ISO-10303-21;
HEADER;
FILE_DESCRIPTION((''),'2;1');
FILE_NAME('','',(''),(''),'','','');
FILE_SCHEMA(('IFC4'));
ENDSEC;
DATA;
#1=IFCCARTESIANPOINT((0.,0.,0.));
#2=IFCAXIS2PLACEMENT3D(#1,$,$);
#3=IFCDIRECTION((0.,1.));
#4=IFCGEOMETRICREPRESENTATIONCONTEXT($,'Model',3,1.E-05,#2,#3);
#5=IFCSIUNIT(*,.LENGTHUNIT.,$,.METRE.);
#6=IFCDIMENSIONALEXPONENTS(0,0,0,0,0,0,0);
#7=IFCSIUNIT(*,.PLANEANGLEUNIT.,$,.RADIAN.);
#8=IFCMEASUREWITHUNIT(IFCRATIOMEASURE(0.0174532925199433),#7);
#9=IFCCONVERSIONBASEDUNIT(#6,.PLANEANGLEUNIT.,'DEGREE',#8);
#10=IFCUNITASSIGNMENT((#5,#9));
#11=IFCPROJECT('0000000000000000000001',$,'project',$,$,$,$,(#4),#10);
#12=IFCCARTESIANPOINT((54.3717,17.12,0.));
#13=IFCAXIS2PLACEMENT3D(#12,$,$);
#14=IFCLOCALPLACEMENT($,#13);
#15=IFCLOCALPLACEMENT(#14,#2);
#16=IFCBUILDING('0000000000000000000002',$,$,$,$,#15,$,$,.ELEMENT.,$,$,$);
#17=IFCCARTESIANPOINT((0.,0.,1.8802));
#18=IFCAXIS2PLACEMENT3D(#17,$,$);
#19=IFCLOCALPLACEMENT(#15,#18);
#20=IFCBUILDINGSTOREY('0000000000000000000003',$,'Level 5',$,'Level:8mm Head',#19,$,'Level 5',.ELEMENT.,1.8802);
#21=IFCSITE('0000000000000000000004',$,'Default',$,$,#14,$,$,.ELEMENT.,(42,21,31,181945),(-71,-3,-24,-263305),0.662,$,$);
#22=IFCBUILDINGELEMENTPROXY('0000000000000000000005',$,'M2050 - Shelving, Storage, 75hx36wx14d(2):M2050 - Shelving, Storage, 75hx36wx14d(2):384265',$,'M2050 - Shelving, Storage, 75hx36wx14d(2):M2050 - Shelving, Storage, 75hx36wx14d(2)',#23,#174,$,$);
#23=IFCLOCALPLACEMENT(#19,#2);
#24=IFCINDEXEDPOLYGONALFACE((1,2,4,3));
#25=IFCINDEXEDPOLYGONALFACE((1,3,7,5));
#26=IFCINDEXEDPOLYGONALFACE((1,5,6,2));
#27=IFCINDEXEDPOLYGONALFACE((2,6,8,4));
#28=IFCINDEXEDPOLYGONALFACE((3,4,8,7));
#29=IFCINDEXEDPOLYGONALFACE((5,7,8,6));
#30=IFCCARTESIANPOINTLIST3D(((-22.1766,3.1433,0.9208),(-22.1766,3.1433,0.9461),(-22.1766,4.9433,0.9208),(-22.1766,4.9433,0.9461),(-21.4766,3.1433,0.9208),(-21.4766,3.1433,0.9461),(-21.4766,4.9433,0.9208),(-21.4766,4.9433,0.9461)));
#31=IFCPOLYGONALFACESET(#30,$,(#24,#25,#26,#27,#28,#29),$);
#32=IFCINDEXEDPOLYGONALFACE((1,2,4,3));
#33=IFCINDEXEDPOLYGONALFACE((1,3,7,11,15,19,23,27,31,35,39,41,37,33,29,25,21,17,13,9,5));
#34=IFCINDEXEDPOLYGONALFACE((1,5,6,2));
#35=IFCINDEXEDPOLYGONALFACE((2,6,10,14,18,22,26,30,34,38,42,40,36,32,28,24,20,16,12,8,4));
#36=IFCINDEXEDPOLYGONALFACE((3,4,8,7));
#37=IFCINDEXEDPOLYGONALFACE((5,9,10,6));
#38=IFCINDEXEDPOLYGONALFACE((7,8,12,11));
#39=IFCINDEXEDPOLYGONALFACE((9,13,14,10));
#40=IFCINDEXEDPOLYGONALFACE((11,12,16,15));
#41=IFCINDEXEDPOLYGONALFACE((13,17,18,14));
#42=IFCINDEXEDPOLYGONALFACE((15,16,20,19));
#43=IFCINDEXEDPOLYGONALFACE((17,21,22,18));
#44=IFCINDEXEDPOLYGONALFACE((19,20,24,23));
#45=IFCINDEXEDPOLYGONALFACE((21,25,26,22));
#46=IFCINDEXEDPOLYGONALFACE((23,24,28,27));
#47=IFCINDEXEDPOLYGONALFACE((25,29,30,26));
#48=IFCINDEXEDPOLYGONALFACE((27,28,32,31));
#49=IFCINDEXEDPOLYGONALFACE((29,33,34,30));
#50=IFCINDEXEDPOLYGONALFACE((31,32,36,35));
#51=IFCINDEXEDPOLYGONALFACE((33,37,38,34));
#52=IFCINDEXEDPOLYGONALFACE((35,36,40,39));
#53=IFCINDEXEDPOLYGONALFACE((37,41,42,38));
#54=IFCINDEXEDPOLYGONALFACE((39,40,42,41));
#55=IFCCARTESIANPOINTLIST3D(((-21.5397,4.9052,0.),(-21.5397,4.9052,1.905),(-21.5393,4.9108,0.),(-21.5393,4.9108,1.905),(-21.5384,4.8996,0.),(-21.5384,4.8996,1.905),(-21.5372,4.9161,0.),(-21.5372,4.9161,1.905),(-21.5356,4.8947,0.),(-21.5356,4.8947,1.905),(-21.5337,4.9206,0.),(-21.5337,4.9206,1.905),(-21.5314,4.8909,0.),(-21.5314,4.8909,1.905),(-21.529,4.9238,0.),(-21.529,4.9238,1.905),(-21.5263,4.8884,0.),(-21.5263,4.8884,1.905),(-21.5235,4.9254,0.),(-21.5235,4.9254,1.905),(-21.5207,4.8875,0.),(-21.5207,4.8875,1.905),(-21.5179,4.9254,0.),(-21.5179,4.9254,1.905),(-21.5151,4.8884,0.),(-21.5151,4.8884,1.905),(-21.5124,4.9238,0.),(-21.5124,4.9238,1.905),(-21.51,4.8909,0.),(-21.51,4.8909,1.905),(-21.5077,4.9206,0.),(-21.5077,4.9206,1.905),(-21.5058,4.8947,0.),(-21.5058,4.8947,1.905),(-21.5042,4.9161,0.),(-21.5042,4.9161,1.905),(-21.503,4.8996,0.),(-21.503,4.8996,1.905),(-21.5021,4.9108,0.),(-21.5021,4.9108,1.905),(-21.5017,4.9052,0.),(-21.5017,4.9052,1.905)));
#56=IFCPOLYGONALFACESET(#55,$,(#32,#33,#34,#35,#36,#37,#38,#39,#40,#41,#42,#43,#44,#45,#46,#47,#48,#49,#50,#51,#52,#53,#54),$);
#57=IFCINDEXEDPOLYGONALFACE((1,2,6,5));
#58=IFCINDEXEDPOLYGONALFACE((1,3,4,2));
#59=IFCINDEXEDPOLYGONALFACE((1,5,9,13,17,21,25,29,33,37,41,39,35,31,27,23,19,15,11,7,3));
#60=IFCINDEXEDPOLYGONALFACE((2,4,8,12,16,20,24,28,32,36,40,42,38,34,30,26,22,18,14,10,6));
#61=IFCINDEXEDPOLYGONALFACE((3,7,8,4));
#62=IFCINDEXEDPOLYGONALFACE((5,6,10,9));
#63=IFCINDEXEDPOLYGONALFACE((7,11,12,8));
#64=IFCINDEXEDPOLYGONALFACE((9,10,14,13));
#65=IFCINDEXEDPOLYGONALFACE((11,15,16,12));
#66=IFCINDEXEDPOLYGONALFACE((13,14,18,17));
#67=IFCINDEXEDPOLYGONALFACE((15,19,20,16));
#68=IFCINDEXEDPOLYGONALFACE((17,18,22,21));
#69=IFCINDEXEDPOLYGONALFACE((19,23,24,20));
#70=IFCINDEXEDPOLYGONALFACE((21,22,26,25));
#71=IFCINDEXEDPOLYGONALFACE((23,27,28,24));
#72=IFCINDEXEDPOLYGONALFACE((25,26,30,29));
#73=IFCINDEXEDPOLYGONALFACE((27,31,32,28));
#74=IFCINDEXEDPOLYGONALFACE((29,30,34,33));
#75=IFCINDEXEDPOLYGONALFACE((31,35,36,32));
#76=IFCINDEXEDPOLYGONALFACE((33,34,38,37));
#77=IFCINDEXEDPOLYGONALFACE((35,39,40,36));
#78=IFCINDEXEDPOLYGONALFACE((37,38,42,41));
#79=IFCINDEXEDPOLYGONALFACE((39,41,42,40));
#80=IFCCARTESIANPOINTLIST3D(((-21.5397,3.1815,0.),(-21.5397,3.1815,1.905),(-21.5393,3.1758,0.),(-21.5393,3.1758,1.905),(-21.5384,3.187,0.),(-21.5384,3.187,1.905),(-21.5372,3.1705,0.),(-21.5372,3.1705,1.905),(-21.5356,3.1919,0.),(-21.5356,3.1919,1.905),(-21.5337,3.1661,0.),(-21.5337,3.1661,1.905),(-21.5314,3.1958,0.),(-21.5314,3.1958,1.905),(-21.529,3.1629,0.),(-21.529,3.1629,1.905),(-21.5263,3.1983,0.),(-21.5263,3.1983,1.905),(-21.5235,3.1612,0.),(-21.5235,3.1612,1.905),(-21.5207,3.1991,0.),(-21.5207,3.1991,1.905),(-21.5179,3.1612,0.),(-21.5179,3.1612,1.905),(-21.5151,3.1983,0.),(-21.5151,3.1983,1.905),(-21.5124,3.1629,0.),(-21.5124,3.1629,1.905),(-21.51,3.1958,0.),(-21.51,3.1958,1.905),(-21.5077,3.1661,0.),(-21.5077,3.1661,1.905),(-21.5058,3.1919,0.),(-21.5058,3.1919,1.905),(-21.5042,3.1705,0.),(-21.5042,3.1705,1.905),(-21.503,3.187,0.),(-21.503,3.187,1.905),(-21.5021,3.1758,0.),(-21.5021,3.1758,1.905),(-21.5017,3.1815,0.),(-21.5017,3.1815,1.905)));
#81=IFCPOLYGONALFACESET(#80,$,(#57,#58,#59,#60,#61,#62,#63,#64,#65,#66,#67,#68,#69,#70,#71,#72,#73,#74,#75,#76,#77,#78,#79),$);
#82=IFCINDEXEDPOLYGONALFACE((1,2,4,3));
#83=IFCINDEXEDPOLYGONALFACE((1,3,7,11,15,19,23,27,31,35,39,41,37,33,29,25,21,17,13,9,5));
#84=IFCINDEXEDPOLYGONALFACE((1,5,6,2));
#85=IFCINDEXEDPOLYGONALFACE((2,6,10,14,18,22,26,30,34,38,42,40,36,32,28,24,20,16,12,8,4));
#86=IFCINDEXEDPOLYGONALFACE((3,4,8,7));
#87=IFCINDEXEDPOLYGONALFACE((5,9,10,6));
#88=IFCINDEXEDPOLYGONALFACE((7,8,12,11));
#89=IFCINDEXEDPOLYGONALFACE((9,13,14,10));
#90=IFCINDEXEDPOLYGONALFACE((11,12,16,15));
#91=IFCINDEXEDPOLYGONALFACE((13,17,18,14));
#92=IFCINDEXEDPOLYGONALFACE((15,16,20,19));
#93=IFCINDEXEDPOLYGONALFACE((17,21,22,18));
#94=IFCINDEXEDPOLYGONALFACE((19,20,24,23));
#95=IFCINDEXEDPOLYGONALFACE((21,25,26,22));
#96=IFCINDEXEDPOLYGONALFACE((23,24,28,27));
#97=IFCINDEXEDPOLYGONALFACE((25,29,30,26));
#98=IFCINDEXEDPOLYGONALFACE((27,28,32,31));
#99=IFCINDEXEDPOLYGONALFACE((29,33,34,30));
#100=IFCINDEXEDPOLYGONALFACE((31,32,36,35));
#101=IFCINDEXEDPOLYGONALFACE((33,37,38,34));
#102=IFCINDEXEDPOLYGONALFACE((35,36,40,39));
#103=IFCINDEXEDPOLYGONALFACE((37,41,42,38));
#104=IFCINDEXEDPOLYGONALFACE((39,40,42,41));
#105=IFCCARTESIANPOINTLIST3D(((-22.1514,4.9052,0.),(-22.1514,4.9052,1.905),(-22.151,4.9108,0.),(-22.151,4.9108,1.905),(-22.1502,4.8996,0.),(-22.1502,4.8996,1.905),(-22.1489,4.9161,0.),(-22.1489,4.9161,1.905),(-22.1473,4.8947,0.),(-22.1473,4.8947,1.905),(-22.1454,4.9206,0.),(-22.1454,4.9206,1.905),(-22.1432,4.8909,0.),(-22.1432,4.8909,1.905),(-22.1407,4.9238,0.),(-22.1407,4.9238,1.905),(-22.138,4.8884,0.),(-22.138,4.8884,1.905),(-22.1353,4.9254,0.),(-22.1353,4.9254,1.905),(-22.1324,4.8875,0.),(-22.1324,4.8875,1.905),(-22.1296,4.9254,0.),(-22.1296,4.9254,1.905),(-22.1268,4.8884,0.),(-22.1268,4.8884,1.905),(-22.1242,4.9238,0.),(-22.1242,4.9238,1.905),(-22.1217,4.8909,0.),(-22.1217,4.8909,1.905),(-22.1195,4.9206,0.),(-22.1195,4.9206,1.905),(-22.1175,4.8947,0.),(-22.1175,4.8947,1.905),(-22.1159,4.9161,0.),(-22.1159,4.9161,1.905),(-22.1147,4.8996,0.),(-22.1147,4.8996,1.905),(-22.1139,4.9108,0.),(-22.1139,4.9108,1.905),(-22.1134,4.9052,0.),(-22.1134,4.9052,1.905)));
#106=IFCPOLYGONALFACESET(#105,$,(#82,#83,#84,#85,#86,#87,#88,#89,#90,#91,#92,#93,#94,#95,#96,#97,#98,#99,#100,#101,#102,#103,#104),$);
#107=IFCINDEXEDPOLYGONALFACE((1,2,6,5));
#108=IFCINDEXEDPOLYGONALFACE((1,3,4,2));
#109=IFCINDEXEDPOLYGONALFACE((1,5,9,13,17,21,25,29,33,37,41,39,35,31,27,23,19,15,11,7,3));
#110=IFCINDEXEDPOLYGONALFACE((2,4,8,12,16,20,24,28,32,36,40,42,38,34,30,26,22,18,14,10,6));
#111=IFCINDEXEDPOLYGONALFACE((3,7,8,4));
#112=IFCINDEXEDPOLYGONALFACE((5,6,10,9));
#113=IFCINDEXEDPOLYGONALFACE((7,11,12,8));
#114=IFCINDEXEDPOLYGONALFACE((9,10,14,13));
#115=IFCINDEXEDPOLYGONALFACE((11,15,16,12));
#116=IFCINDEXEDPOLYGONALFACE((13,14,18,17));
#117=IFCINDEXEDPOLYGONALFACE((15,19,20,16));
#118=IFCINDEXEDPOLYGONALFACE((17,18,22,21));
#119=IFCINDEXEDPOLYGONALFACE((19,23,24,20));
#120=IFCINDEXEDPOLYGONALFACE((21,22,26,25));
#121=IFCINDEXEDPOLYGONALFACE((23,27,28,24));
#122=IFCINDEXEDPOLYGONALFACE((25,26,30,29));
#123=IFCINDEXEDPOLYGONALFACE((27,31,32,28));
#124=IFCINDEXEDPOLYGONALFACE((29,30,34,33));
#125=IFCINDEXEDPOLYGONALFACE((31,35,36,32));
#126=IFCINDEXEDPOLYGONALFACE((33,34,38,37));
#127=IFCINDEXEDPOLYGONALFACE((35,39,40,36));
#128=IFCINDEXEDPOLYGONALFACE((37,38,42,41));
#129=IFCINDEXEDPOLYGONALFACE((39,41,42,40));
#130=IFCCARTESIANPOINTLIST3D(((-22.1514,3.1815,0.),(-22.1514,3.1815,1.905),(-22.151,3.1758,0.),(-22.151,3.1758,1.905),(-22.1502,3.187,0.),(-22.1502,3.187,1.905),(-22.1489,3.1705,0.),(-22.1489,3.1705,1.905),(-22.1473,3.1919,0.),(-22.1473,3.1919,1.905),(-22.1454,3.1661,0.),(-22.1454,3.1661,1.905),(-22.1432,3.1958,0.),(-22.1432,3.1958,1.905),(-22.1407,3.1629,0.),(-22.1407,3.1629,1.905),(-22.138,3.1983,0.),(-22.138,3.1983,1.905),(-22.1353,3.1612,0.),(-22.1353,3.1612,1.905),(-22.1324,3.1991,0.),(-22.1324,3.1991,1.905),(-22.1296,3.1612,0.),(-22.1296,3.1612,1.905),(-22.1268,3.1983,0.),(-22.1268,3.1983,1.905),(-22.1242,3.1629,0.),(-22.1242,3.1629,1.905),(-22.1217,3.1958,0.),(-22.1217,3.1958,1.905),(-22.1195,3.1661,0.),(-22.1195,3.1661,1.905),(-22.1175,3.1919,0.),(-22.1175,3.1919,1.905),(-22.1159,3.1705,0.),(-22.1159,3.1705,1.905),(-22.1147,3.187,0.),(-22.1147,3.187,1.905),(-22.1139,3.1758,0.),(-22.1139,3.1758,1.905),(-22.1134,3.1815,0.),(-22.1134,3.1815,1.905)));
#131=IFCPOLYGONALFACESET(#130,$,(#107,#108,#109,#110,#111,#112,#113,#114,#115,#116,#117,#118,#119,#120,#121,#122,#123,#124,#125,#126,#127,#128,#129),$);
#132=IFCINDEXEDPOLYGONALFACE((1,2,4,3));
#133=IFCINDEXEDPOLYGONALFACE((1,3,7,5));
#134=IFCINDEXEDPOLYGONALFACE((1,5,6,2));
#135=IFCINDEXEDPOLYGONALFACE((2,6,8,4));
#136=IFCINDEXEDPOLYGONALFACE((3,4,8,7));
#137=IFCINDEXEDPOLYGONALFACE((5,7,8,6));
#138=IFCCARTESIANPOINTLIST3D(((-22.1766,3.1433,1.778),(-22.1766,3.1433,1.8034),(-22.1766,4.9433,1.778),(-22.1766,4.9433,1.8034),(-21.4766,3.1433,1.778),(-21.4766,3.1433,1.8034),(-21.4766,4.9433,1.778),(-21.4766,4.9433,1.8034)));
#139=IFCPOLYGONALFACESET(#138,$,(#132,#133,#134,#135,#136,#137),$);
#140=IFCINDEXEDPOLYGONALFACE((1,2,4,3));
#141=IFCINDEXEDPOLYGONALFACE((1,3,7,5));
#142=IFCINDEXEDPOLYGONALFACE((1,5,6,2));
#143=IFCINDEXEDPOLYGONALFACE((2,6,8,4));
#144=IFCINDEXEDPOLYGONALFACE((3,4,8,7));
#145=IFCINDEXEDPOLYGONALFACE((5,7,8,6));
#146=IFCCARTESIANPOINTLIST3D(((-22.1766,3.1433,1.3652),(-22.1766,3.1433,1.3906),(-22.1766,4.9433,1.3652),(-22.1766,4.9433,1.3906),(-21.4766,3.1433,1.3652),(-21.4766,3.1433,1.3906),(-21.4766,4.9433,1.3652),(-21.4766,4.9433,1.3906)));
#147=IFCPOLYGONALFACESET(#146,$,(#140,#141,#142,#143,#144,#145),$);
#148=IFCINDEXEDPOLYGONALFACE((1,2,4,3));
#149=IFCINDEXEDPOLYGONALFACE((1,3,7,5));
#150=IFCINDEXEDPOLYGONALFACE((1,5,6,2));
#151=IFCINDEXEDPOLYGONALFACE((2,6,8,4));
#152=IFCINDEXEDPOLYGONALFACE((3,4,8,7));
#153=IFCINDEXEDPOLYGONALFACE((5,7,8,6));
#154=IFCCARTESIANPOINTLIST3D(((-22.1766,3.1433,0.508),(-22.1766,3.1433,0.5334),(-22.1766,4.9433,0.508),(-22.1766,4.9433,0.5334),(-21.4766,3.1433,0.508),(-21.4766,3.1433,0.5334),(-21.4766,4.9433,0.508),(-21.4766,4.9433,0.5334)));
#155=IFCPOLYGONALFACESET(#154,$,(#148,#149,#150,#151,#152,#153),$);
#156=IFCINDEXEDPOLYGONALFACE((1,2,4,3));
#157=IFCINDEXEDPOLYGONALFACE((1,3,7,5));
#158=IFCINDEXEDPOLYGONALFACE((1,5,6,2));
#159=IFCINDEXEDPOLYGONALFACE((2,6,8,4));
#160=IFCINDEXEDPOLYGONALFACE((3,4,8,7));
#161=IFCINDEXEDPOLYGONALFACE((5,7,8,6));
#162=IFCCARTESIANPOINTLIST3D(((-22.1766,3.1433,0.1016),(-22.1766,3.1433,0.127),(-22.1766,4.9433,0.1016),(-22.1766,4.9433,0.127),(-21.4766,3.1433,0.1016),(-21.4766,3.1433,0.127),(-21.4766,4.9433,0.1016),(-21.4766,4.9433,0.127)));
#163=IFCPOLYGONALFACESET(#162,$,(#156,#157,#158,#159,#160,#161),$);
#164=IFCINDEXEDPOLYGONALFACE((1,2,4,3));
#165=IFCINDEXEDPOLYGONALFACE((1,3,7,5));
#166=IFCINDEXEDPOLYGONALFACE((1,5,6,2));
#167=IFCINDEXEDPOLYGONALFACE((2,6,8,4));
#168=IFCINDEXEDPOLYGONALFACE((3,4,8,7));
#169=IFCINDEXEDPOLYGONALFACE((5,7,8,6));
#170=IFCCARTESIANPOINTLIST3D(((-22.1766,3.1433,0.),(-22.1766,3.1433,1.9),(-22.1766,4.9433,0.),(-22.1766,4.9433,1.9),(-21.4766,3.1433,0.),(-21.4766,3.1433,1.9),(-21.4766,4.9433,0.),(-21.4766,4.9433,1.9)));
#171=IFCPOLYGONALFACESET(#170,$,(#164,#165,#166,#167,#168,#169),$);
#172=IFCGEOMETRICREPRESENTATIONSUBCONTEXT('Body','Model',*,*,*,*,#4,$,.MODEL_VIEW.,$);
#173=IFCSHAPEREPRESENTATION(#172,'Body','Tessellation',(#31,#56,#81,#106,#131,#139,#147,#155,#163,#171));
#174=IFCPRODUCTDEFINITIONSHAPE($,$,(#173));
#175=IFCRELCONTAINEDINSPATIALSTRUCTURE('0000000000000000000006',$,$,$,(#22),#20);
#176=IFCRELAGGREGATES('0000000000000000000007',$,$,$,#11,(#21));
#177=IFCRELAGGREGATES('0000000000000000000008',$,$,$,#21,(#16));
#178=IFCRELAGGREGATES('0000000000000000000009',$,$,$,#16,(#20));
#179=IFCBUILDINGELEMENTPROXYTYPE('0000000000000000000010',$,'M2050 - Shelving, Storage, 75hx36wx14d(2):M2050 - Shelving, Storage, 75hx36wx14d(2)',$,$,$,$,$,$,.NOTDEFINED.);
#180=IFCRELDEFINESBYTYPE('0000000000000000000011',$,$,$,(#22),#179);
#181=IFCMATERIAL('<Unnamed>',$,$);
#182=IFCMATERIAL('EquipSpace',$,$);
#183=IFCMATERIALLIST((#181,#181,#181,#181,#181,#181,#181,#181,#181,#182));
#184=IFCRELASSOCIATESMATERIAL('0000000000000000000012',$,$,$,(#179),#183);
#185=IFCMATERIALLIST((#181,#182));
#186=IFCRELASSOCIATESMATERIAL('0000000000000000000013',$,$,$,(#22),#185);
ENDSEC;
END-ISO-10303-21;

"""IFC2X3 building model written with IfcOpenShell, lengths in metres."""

from ifc_helpers import new_model, entity, si_unit, converted_unit, direction, frame, frame_2d, origin, origin_2d_with_axis, place, context, subcontext, project, spatial, rectangle, circle, extrude, source, transform, mapped, material, material_list, type_object, type_shapes, element, save


model = new_model("IFC2X3")

# Units and contexts
model_context = context("Model", 3, precision=1e-05, world=origin(), true_north=direction((0.0, 1.0)))
body_context = subcontext(model_context, "Body", "Model", "MODEL_VIEW")
ifc_project = project(units=[si_unit("LENGTHUNIT", "METRE"), converted_unit("PLANEANGLEUNIT", "DEGREE", entity("IfcRatioMeasure", 0.0174532925199433), si_unit("PLANEANGLEUNIT", "RADIAN"), dimensions=[0, 0, 0, 0, 0, 0, 0])], contexts=[model_context])

# Site, building, storey
site_placement = place(None, frame((54.3717, 17.12, 0.0)))
site = spatial("IfcSite", under=ifc_project, at=site_placement, Name="Default", CompositionType="ELEMENT", RefLatitude=(42, 21, 31, 181945), RefLongitude=(-71, -3, -24, -263305), RefElevation=0.662)
building_placement = place(site_placement, origin())
building = spatial("IfcBuilding", under=site, at=building_placement, CompositionType="ELEMENT")
storey_placement = place(building_placement, frame((0.0, 0.0, 1.8802)))
storey = spatial("IfcBuildingStorey", under=building, at=storey_placement, Name="Level 5", ObjectType="Level:8mm Head", LongName="Level 5", CompositionType="ELEMENT", Elevation=1.8802)

# Building element proxy
ifc_material_1 = material(Name="<Unnamed>")
ifc_material_2 = material(Name="EquipSpace")
ifc_material_list_1 = material_list([ifc_material_1, ifc_material_1, ifc_material_1, ifc_material_1, ifc_material_1, ifc_material_1, ifc_material_1, ifc_material_1, ifc_material_1, ifc_material_2])
building_element_proxy_type = type_object("IfcBuildingElementProxyType", Name="M2050 - Shelving, Storage, 75hx36wx14d(2):M2050 - Shelving, Storage, 75hx36wx14d(2)", PredefinedType="NOTDEFINED", material=ifc_material_list_1)
shared_shape = source(origin(), body_context, "Body", "SweptSolid", [
    extrude(rectangle(XDim=1.8, YDim=0.7, at=origin_2d_with_axis()), frame((0.0, 0.0, 0.9207), z_axis=(0.0, 0.0, 1.0), x_axis=(-1.0, 0.0, 0.0)), (0.0, 0.0, 1.0), 0.0254),
    extrude(circle(Radius=0.0191, at=origin_2d_with_axis()), frame((0.8633, -0.3059, 0.0), z_axis=(0.0, 0.0, 1.0), x_axis=(-1.0, 0.0, 0.0)), (0.0, 0.0, 1.0), 1.905),
    extrude(circle(Radius=0.0191, at=origin_2d_with_axis()), frame((-0.8633, -0.3059, 0.0)), (0.0, 0.0, 1.0), 1.905),
    extrude(circle(Radius=0.0191, at=origin_2d_with_axis()), frame((0.8633, 0.3059, 0.0), z_axis=(0.0, 0.0, 1.0), x_axis=(-1.0, 0.0, 0.0)), (0.0, 0.0, 1.0), 1.905),
    extrude(circle(Radius=0.0191, at=origin_2d_with_axis()), frame((-0.8633, 0.3059, 0.0)), (0.0, 0.0, 1.0), 1.905),
    extrude(rectangle(XDim=1.8, YDim=0.7, at=origin_2d_with_axis()), frame((0.0, 0.0, 1.778), z_axis=(0.0, 0.0, 1.0), x_axis=(-1.0, 0.0, 0.0)), (0.0, 0.0, 1.0), 0.0254),
    extrude(rectangle(XDim=1.8, YDim=0.7, at=origin_2d_with_axis()), frame((0.0, 0.0, 1.3653), z_axis=(0.0, 0.0, 1.0), x_axis=(-1.0, 0.0, 0.0)), (0.0, 0.0, 1.0), 0.0254),
    extrude(rectangle(XDim=1.8, YDim=0.7, at=origin_2d_with_axis()), frame((0.0, 0.0, 0.508), z_axis=(0.0, 0.0, 1.0), x_axis=(-1.0, 0.0, 0.0)), (0.0, 0.0, 1.0), 0.0254),
    extrude(rectangle(XDim=1.8, YDim=0.7, at=origin_2d_with_axis()), frame((0.0, 0.0, 0.1016), z_axis=(0.0, 0.0, 1.0), x_axis=(-1.0, 0.0, 0.0)), (0.0, 0.0, 1.0), 0.0254),
    extrude(rectangle(XDim=0.7, YDim=1.8, at=frame_2d((0.0, 0.18), x_axis=(1.0, 0.0))), frame((-0.18, 0.0, 0.0), z_axis=(0.0, 0.0, 1.0), x_axis=(0.0, -1.0, 0.0)), (0.0, 0.0, 1.0), 1.9),
])
type_shapes(building_element_proxy_type, [shared_shape])
ifc_material_list_2 = material_list([ifc_material_1, ifc_material_2])
proxy_1_placement = place(storey_placement, frame((-21.8266, 4.0433, 0.0), z_axis=(0.0, 0.0, 1.0), x_axis=(0.0, 1.0, 0.0)))
element("IfcBuildingElementProxy", 1, at=proxy_1_placement, inside=storey, type_object=building_element_proxy_type, material=ifc_material_list_2, Name="M2050 - Shelving, Storage, 75hx36wx14d(2):M2050 - Shelving, Storage, 75hx36wx14d(2):384265", ObjectType="M2050 - Shelving, Storage, 75hx36wx14d(2):M2050 - Shelving, Storage, 75hx36wx14d(2)", context=body_context, shape_type="MappedRepresentation", body=[
    mapped(shared_shape, transform((0.0, 0.0, 0.0), scale=1.0)),
])

save(model, "model.ifc")
